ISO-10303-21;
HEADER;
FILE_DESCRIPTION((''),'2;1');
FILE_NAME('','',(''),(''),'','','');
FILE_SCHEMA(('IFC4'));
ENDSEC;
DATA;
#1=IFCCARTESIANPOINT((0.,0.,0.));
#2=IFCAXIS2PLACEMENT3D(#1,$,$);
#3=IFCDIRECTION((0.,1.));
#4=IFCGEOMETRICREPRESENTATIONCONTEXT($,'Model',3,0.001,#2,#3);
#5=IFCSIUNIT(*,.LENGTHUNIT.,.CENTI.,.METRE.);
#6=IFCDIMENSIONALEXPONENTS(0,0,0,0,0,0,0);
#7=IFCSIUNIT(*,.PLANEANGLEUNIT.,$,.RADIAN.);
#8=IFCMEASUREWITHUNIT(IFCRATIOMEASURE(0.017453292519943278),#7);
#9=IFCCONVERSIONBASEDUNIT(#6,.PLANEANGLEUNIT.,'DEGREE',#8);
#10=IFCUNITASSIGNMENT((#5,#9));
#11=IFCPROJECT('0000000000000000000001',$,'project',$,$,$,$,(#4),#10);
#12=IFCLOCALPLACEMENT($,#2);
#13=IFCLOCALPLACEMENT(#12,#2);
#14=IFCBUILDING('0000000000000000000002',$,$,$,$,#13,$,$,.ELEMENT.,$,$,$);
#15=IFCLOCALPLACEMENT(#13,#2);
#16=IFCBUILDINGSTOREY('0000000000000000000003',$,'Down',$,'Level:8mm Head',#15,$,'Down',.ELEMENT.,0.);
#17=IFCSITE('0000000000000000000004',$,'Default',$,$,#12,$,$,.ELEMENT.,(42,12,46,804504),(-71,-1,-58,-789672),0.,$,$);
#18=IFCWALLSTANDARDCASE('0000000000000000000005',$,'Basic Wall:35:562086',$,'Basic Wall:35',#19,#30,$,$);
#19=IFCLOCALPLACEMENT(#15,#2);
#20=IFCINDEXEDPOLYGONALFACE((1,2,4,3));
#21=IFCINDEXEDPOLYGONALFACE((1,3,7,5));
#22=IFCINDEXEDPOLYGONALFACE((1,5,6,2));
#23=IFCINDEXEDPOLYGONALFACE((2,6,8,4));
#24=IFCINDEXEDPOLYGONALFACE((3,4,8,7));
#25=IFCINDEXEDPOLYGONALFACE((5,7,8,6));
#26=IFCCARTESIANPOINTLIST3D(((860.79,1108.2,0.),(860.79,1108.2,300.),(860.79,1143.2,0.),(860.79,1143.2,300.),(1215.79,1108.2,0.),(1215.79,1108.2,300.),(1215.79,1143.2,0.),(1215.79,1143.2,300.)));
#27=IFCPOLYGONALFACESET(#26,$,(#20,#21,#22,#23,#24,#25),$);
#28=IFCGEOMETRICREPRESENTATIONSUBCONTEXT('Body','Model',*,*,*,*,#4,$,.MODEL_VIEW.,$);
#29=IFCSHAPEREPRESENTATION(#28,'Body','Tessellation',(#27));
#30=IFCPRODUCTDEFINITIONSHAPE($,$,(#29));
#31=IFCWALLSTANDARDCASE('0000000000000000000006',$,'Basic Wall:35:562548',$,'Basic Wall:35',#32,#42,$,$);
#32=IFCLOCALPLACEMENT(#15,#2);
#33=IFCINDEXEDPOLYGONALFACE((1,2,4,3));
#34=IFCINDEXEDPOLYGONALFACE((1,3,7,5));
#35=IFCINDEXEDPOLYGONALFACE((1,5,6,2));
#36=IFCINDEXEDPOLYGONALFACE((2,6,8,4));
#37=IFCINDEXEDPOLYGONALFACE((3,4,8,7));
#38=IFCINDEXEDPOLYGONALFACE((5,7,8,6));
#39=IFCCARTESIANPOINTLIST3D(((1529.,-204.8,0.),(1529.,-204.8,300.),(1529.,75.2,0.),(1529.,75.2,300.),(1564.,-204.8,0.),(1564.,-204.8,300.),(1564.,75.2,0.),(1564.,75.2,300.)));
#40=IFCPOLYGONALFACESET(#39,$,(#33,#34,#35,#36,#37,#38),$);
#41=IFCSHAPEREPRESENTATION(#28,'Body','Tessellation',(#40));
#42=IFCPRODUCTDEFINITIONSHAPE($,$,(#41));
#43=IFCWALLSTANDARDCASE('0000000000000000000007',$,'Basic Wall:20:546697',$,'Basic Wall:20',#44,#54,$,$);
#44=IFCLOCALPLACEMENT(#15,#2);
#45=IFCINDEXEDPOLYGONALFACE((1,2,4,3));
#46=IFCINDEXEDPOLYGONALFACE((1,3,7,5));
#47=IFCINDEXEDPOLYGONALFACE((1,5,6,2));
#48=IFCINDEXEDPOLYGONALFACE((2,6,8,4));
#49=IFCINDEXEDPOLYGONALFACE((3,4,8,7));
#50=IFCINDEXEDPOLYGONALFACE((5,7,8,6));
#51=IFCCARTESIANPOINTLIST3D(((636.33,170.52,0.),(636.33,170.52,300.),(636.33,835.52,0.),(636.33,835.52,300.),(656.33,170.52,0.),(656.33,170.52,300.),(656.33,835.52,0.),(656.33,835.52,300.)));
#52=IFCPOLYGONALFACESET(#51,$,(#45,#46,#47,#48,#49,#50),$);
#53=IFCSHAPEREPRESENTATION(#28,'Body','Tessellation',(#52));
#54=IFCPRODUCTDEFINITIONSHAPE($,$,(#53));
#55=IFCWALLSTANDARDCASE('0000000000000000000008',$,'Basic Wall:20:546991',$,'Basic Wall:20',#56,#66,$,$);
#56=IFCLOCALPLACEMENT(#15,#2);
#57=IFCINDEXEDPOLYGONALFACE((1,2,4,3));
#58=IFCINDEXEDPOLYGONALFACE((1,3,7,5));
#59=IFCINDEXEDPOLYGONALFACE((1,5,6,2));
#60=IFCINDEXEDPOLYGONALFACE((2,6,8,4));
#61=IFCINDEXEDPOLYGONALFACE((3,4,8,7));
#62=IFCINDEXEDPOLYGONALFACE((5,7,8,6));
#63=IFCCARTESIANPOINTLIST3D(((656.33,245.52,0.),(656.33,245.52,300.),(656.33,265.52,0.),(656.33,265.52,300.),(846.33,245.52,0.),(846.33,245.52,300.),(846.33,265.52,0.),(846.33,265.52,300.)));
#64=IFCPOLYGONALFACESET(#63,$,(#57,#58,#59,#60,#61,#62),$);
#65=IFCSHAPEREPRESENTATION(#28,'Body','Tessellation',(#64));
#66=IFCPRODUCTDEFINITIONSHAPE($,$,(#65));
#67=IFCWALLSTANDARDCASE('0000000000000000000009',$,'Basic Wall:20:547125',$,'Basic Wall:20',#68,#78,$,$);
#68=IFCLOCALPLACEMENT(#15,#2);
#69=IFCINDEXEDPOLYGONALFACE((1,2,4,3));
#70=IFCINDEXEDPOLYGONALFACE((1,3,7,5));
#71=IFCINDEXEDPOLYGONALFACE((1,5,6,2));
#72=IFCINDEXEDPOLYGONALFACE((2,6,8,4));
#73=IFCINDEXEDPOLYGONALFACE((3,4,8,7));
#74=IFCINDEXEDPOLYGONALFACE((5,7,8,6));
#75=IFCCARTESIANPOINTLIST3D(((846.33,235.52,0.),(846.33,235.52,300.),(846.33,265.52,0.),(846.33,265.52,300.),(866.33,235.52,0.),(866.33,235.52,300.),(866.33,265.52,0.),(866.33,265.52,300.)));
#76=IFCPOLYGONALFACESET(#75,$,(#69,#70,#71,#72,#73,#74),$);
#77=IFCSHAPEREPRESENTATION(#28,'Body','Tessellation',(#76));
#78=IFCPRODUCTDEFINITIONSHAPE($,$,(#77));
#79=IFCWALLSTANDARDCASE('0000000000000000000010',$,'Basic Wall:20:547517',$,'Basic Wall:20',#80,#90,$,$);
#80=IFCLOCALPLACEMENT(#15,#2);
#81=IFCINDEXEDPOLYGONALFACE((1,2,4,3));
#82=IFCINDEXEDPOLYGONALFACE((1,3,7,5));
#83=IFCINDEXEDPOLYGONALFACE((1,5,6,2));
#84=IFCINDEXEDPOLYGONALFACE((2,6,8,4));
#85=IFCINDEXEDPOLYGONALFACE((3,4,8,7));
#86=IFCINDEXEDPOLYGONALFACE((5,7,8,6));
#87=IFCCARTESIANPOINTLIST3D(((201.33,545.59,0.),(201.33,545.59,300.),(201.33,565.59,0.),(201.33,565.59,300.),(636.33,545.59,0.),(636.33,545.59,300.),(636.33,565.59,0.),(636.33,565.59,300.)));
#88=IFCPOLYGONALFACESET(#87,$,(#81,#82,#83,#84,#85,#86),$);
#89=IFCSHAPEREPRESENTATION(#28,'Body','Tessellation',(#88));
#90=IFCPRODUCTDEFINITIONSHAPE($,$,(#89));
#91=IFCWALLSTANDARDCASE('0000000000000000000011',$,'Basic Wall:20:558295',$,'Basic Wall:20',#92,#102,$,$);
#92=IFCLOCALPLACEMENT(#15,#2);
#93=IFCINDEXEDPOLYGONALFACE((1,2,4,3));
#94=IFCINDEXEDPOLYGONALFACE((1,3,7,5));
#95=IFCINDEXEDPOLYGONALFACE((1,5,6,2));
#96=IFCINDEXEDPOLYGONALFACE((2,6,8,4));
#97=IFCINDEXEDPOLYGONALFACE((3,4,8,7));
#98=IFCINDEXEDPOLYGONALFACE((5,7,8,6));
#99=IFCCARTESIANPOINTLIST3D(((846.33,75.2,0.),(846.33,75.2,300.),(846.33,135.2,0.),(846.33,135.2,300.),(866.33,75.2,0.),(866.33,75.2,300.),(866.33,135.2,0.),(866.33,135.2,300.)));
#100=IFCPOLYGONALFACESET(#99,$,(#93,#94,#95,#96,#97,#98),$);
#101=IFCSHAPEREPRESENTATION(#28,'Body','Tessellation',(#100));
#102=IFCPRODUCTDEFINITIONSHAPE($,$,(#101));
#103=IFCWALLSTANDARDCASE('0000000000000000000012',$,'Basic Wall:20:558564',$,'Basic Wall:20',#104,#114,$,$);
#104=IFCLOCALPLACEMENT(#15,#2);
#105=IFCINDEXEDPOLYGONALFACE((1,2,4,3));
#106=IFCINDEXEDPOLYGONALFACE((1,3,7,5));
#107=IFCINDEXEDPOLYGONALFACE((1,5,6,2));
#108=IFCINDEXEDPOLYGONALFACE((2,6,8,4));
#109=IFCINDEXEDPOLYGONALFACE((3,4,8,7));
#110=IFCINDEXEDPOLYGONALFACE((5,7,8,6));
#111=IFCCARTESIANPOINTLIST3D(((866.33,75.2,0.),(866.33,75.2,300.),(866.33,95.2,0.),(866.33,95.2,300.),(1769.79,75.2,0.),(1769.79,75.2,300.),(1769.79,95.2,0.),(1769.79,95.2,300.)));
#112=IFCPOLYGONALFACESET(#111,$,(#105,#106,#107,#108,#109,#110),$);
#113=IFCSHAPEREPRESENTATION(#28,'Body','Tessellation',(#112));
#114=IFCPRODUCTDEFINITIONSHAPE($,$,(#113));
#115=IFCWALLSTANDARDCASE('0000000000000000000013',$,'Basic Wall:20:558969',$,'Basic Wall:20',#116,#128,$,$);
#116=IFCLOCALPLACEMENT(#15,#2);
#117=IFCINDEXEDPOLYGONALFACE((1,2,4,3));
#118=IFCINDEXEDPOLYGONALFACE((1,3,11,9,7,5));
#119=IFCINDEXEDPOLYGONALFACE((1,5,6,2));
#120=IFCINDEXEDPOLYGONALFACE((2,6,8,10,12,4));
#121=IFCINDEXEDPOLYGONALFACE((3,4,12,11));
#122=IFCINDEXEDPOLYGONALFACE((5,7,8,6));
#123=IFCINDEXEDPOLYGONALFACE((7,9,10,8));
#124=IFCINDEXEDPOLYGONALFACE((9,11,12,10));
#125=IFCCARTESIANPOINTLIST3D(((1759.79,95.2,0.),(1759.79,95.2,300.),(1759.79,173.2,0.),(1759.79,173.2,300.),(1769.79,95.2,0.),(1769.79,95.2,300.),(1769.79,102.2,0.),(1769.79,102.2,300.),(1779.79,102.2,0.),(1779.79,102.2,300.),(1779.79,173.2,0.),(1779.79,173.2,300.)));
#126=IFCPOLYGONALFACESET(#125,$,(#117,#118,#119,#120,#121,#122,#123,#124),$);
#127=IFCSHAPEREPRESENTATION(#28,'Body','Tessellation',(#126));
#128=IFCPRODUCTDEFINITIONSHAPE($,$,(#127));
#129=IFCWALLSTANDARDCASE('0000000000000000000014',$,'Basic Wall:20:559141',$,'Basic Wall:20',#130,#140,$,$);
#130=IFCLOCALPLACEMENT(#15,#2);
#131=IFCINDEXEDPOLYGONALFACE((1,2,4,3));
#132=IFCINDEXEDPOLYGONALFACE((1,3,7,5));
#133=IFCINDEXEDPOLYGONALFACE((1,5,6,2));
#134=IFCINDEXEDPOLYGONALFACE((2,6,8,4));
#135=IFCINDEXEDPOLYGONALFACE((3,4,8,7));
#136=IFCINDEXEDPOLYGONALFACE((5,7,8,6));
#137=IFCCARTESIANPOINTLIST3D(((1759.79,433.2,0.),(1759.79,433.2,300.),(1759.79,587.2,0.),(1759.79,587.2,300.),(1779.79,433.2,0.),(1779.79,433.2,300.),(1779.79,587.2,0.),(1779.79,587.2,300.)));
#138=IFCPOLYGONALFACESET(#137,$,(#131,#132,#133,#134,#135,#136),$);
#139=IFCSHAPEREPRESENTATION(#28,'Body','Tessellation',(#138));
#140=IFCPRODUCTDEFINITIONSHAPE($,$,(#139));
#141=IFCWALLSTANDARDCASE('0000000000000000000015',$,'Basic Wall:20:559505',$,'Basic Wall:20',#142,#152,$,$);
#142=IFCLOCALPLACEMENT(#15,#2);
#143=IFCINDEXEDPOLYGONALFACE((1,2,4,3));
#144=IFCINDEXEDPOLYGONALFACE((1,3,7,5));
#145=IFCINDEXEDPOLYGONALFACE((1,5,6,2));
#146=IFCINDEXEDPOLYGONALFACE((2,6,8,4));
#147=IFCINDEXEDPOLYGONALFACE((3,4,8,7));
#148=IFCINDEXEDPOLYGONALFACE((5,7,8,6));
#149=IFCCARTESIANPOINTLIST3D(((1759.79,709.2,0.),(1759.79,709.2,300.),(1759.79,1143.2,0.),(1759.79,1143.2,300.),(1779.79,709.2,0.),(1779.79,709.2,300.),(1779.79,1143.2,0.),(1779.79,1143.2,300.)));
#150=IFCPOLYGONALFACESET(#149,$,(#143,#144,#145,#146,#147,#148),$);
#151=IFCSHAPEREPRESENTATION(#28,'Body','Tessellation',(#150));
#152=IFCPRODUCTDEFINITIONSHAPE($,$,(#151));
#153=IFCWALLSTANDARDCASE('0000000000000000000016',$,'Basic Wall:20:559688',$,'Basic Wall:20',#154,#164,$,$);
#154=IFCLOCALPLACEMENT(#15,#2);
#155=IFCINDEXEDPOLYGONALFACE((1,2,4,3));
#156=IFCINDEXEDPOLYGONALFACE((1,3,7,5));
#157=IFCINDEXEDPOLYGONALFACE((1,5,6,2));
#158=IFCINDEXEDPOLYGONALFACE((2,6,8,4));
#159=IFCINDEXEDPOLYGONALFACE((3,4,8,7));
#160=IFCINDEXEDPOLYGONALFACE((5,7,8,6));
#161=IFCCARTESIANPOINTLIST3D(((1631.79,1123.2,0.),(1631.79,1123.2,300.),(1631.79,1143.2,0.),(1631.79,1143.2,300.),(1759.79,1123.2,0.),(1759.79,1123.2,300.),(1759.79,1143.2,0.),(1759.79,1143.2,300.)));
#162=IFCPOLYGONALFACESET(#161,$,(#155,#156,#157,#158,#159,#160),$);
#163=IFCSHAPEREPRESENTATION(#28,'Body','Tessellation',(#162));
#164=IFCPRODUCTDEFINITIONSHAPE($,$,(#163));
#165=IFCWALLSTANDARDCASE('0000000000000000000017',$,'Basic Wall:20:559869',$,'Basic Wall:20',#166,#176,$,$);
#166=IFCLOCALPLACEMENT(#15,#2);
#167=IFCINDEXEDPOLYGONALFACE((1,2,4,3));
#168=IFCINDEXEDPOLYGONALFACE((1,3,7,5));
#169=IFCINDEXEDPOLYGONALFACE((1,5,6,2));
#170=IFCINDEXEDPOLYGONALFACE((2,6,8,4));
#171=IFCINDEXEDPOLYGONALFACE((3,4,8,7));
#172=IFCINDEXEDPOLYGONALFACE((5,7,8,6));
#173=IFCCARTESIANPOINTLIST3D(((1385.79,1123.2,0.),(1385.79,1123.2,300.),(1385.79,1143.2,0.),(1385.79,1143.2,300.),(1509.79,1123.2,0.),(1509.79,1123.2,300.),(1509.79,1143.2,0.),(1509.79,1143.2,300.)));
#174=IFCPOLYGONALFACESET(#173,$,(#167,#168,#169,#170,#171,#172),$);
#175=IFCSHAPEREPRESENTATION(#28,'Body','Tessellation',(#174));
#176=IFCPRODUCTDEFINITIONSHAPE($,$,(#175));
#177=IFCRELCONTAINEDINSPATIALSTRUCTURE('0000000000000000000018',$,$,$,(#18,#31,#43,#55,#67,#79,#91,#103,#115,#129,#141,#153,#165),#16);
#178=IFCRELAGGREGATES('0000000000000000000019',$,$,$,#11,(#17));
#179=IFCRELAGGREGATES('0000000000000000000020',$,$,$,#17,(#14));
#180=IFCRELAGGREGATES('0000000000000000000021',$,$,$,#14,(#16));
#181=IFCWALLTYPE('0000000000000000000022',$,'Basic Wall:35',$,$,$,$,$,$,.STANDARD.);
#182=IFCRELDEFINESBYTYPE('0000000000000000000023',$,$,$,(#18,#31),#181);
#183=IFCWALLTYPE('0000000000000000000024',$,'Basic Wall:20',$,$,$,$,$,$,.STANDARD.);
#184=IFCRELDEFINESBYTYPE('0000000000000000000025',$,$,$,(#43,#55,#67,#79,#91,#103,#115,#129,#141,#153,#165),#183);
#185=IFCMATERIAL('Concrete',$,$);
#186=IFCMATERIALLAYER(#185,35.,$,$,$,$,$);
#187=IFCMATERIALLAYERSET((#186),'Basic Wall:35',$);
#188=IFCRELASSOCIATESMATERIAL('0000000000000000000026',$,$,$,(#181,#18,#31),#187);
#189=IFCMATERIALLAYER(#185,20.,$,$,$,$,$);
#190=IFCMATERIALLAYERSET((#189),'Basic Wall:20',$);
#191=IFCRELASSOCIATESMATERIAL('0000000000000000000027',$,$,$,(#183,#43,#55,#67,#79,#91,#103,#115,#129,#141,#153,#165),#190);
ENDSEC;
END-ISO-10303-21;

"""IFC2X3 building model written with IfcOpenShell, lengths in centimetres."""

from ifc_helpers import new_model, entity, si_unit, converted_unit, direction, frame, frame_2d, origin, place, context, subcontext, project, spatial, polyline, rectangle, outline, extrude, material, layer, layer_set, layer_usage, type_object, element, save


model = new_model("IFC2X3")

# Units and contexts
model_context = context("Model", 3, precision=0.001, world=origin(), true_north=direction((0.0, 1.0)))
body_context = subcontext(model_context, "Body", "Model", "MODEL_VIEW")
ifc_project = project(units=[si_unit("LENGTHUNIT", "METRE", prefix="CENTI"), converted_unit("PLANEANGLEUNIT", "DEGREE", entity("IfcRatioMeasure", 0.017453292519943278), si_unit("PLANEANGLEUNIT", "RADIAN"), dimensions=[0, 0, 0, 0, 0, 0, 0])], contexts=[model_context])

# Site, building, storey
site_placement = place(None, origin())
site = spatial("IfcSite", under=ifc_project, at=site_placement, Name="Default", CompositionType="ELEMENT", RefLatitude=(42, 12, 46, 804504), RefLongitude=(-71, -1, -58, -789672), RefElevation=0.0)
building_placement = place(site_placement, origin())
building = spatial("IfcBuilding", under=site, at=building_placement, CompositionType="ELEMENT")
storey_placement = place(building_placement, origin())
storey = spatial("IfcBuildingStorey", under=building, at=storey_placement, Name="Down", ObjectType="Level:8mm Head", LongName="Down", CompositionType="ELEMENT", Elevation=0.0)

# Walls
ifc_material = material(Name="Concrete")
ifc_layer_1 = layer(ifc_material, 35.0)
ifc_layer_set_1 = layer_set([ifc_layer_1], Name="Basic Wall:35")
ifc_layer_usage_1 = layer_usage(ifc_layer_set_1, "AXIS2", "NEGATIVE", 17.5)
wall_type_1 = type_object("IfcWallType", Name="Basic Wall:35", PredefinedType="STANDARD", material=ifc_layer_set_1)
wall_1_placement = place(storey_placement, frame((860.79, 1125.7, 0.0)))
element("IfcWallStandardCase", 1, at=wall_1_placement, inside=storey, type_object=wall_type_1, material=ifc_layer_usage_1, Name="Basic Wall:35:562086", ObjectType="Basic Wall:35", context=body_context, shape_type="SweptSolid", body=[
    extrude(rectangle(XDim=355.0, YDim=35.0, at=frame_2d((177.5, 0.0), x_axis=(-1.0, 0.0))), origin(), (0.0, 0.0, 1.0), 300.0),
])
ifc_layer_usage_2 = layer_usage(ifc_layer_set_1, "AXIS2", "NEGATIVE", 17.5)
wall_2_placement = place(storey_placement, frame((1546.5, 75.2, 0.0), z_axis=(0.0, 0.0, 1.0), x_axis=(0.0, -1.0, 0.0)))
element("IfcWallStandardCase", 2, at=wall_2_placement, inside=storey, type_object=wall_type_1, material=ifc_layer_usage_2, Name="Basic Wall:35:562548", ObjectType="Basic Wall:35", context=body_context, shape_type="SweptSolid", body=[
    extrude(rectangle(XDim=280.0, YDim=35.0, at=frame_2d((140.0, 0.0), x_axis=(-1.0, 0.0))), origin(), (0.0, 0.0, 1.0), 300.0),
])
ifc_layer_2 = layer(ifc_material, 20.0)
ifc_layer_set_2 = layer_set([ifc_layer_2], Name="Basic Wall:20")
ifc_layer_usage_3 = layer_usage(ifc_layer_set_2, "AXIS2", "NEGATIVE", 10.0)
wall_type_2 = type_object("IfcWallType", Name="Basic Wall:20", PredefinedType="STANDARD", material=ifc_layer_set_2)
wall_3_placement = place(storey_placement, frame((646.33, 835.52, 0.0), z_axis=(0.0, 0.0, 1.0), x_axis=(0.0, -1.0, 0.0)))
element("IfcWallStandardCase", 3, at=wall_3_placement, inside=storey, type_object=wall_type_2, material=ifc_layer_usage_3, Name="Basic Wall:20:546697", ObjectType="Basic Wall:20", context=body_context, shape_type="SweptSolid", body=[
    extrude(rectangle(XDim=665.0, YDim=20.0, at=frame_2d((332.5, 0.0), x_axis=(-1.0, 0.0))), origin(), (0.0, 0.0, 1.0), 300.0),
])
ifc_layer_usage_4 = layer_usage(ifc_layer_set_2, "AXIS2", "NEGATIVE", 10.0)
wall_4_placement = place(storey_placement, frame((656.33, 255.52, 0.0)))
element("IfcWallStandardCase", 4, at=wall_4_placement, inside=storey, type_object=wall_type_2, material=ifc_layer_usage_4, Name="Basic Wall:20:546991", ObjectType="Basic Wall:20", context=body_context, shape_type="SweptSolid", body=[
    extrude(rectangle(XDim=190.0, YDim=20.0, at=frame_2d((95.0, 0.0), x_axis=(-1.0, 0.0))), origin(), (0.0, 0.0, 1.0), 300.0),
])
ifc_layer_usage_5 = layer_usage(ifc_layer_set_2, "AXIS2", "NEGATIVE", 10.0)
wall_5_placement = place(storey_placement, frame((856.33, 265.52, 0.0), z_axis=(0.0, 0.0, 1.0), x_axis=(0.0, -1.0, 0.0)))
element("IfcWallStandardCase", 5, at=wall_5_placement, inside=storey, type_object=wall_type_2, material=ifc_layer_usage_5, Name="Basic Wall:20:547125", ObjectType="Basic Wall:20", context=body_context, shape_type="SweptSolid", body=[
    extrude(rectangle(XDim=30.0, YDim=20.0, at=frame_2d((15.0, 0.0), x_axis=(-1.0, 0.0))), origin(), (0.0, 0.0, 1.0), 300.0),
])
ifc_layer_usage_6 = layer_usage(ifc_layer_set_2, "AXIS2", "POSITIVE", -10.0)
wall_6_placement = place(storey_placement, frame((636.33, 555.59, 0.0), z_axis=(0.0, 0.0, 1.0), x_axis=(-1.0, 0.0, 0.0)))
element("IfcWallStandardCase", 6, at=wall_6_placement, inside=storey, type_object=wall_type_2, material=ifc_layer_usage_6, Name="Basic Wall:20:547517", ObjectType="Basic Wall:20", context=body_context, shape_type="SweptSolid", body=[
    extrude(rectangle(XDim=435.0, YDim=20.0, at=frame_2d((217.5, 0.0), x_axis=(-1.0, 0.0))), origin(), (0.0, 0.0, 1.0), 300.0),
])
ifc_layer_usage_7 = layer_usage(ifc_layer_set_2, "AXIS2", "NEGATIVE", 10.0)
wall_7_placement = place(storey_placement, frame((856.33, 75.2, 0.0), z_axis=(0.0, 0.0, 1.0), x_axis=(0.0, 1.0, 0.0)))
element("IfcWallStandardCase", 7, at=wall_7_placement, inside=storey, type_object=wall_type_2, material=ifc_layer_usage_7, Name="Basic Wall:20:558295", ObjectType="Basic Wall:20", context=body_context, shape_type="SweptSolid", body=[
    extrude(rectangle(XDim=60.0, YDim=20.0, at=frame_2d((30.0, 0.0), x_axis=(-1.0, 0.0))), origin(), (0.0, 0.0, 1.0), 300.0),
])
ifc_layer_usage_8 = layer_usage(ifc_layer_set_2, "AXIS2", "NEGATIVE", 10.0)
wall_8_placement = place(storey_placement, frame((866.33, 85.2, 0.0)))
element("IfcWallStandardCase", 8, at=wall_8_placement, inside=storey, type_object=wall_type_2, material=ifc_layer_usage_8, Name="Basic Wall:20:558564", ObjectType="Basic Wall:20", context=body_context, shape_type="SweptSolid", body=[
    extrude(rectangle(XDim=903.46, YDim=20.0, at=frame_2d((451.73, 0.0), x_axis=(-1.0, 0.0))), origin(), (0.0, 0.0, 1.0), 300.0),
])
ifc_layer_usage_9 = layer_usage(ifc_layer_set_2, "AXIS2", "NEGATIVE", 10.0)
wall_9_placement = place(storey_placement, frame((1769.79, 95.2, 0.0), z_axis=(0.0, 0.0, 1.0), x_axis=(0.0, 1.0, 0.0)))
element("IfcWallStandardCase", 9, at=wall_9_placement, inside=storey, type_object=wall_type_2, material=ifc_layer_usage_9, Name="Basic Wall:20:558969", ObjectType="Basic Wall:20", context=body_context, shape_type="SweptSolid", body=[
    extrude(outline(polyline([(78.0, -10.0), (78.0, 10.0), (0.0, 10.0), (0.0, 0.0), (7.0, 0.0), (7.0, -10.0), (78.0, -10.0)])), origin(), (0.0, 0.0, 1.0), 300.0),
])
ifc_layer_usage_10 = layer_usage(ifc_layer_set_2, "AXIS2", "NEGATIVE", 10.0)
wall_10_placement = place(storey_placement, frame((1769.79, 433.2, 0.0), z_axis=(0.0, 0.0, 1.0), x_axis=(0.0, 1.0, 0.0)))
element("IfcWallStandardCase", 10, at=wall_10_placement, inside=storey, type_object=wall_type_2, material=ifc_layer_usage_10, Name="Basic Wall:20:559141", ObjectType="Basic Wall:20", context=body_context, shape_type="SweptSolid", body=[
    extrude(rectangle(XDim=154.0, YDim=20.0, at=frame_2d((77.0, 0.0), x_axis=(-1.0, 0.0))), origin(), (0.0, 0.0, 1.0), 300.0),
])
ifc_layer_usage_11 = layer_usage(ifc_layer_set_2, "AXIS2", "NEGATIVE", 10.0)
wall_11_placement = place(storey_placement, frame((1769.79, 709.2, 0.0), z_axis=(0.0, 0.0, 1.0), x_axis=(0.0, 1.0, 0.0)))
element("IfcWallStandardCase", 11, at=wall_11_placement, inside=storey, type_object=wall_type_2, material=ifc_layer_usage_11, Name="Basic Wall:20:559505", ObjectType="Basic Wall:20", context=body_context, shape_type="SweptSolid", body=[
    extrude(rectangle(XDim=434.0, YDim=20.0, at=frame_2d((217.0, 0.0), x_axis=(-1.0, 0.0))), origin(), (0.0, 0.0, 1.0), 300.0),
])
ifc_layer_usage_12 = layer_usage(ifc_layer_set_2, "AXIS2", "POSITIVE", -10.0)
wall_12_placement = place(storey_placement, frame((1759.79, 1133.2, 0.0), z_axis=(0.0, 0.0, 1.0), x_axis=(-1.0, 0.0, 0.0)))
element("IfcWallStandardCase", 12, at=wall_12_placement, inside=storey, type_object=wall_type_2, material=ifc_layer_usage_12, Name="Basic Wall:20:559688", ObjectType="Basic Wall:20", context=body_context, shape_type="SweptSolid", body=[
    extrude(rectangle(XDim=128.0, YDim=20.0, at=frame_2d((64.0, 0.0), x_axis=(-1.0, 0.0))), origin(), (0.0, 0.0, 1.0), 300.0),
])
ifc_layer_usage_13 = layer_usage(ifc_layer_set_2, "AXIS2", "POSITIVE", -10.0)
wall_13_placement = place(storey_placement, frame((1509.79, 1133.2, 0.0), z_axis=(0.0, 0.0, 1.0), x_axis=(-1.0, 0.0, 0.0)))
element("IfcWallStandardCase", 13, at=wall_13_placement, inside=storey, type_object=wall_type_2, material=ifc_layer_usage_13, Name="Basic Wall:20:559869", ObjectType="Basic Wall:20", context=body_context, shape_type="SweptSolid", body=[
    extrude(rectangle(XDim=124.0, YDim=20.0, at=frame_2d((62.0, 0.0), x_axis=(-1.0, 0.0))), origin(), (0.0, 0.0, 1.0), 300.0),
])

save(model, "model.ifc")
